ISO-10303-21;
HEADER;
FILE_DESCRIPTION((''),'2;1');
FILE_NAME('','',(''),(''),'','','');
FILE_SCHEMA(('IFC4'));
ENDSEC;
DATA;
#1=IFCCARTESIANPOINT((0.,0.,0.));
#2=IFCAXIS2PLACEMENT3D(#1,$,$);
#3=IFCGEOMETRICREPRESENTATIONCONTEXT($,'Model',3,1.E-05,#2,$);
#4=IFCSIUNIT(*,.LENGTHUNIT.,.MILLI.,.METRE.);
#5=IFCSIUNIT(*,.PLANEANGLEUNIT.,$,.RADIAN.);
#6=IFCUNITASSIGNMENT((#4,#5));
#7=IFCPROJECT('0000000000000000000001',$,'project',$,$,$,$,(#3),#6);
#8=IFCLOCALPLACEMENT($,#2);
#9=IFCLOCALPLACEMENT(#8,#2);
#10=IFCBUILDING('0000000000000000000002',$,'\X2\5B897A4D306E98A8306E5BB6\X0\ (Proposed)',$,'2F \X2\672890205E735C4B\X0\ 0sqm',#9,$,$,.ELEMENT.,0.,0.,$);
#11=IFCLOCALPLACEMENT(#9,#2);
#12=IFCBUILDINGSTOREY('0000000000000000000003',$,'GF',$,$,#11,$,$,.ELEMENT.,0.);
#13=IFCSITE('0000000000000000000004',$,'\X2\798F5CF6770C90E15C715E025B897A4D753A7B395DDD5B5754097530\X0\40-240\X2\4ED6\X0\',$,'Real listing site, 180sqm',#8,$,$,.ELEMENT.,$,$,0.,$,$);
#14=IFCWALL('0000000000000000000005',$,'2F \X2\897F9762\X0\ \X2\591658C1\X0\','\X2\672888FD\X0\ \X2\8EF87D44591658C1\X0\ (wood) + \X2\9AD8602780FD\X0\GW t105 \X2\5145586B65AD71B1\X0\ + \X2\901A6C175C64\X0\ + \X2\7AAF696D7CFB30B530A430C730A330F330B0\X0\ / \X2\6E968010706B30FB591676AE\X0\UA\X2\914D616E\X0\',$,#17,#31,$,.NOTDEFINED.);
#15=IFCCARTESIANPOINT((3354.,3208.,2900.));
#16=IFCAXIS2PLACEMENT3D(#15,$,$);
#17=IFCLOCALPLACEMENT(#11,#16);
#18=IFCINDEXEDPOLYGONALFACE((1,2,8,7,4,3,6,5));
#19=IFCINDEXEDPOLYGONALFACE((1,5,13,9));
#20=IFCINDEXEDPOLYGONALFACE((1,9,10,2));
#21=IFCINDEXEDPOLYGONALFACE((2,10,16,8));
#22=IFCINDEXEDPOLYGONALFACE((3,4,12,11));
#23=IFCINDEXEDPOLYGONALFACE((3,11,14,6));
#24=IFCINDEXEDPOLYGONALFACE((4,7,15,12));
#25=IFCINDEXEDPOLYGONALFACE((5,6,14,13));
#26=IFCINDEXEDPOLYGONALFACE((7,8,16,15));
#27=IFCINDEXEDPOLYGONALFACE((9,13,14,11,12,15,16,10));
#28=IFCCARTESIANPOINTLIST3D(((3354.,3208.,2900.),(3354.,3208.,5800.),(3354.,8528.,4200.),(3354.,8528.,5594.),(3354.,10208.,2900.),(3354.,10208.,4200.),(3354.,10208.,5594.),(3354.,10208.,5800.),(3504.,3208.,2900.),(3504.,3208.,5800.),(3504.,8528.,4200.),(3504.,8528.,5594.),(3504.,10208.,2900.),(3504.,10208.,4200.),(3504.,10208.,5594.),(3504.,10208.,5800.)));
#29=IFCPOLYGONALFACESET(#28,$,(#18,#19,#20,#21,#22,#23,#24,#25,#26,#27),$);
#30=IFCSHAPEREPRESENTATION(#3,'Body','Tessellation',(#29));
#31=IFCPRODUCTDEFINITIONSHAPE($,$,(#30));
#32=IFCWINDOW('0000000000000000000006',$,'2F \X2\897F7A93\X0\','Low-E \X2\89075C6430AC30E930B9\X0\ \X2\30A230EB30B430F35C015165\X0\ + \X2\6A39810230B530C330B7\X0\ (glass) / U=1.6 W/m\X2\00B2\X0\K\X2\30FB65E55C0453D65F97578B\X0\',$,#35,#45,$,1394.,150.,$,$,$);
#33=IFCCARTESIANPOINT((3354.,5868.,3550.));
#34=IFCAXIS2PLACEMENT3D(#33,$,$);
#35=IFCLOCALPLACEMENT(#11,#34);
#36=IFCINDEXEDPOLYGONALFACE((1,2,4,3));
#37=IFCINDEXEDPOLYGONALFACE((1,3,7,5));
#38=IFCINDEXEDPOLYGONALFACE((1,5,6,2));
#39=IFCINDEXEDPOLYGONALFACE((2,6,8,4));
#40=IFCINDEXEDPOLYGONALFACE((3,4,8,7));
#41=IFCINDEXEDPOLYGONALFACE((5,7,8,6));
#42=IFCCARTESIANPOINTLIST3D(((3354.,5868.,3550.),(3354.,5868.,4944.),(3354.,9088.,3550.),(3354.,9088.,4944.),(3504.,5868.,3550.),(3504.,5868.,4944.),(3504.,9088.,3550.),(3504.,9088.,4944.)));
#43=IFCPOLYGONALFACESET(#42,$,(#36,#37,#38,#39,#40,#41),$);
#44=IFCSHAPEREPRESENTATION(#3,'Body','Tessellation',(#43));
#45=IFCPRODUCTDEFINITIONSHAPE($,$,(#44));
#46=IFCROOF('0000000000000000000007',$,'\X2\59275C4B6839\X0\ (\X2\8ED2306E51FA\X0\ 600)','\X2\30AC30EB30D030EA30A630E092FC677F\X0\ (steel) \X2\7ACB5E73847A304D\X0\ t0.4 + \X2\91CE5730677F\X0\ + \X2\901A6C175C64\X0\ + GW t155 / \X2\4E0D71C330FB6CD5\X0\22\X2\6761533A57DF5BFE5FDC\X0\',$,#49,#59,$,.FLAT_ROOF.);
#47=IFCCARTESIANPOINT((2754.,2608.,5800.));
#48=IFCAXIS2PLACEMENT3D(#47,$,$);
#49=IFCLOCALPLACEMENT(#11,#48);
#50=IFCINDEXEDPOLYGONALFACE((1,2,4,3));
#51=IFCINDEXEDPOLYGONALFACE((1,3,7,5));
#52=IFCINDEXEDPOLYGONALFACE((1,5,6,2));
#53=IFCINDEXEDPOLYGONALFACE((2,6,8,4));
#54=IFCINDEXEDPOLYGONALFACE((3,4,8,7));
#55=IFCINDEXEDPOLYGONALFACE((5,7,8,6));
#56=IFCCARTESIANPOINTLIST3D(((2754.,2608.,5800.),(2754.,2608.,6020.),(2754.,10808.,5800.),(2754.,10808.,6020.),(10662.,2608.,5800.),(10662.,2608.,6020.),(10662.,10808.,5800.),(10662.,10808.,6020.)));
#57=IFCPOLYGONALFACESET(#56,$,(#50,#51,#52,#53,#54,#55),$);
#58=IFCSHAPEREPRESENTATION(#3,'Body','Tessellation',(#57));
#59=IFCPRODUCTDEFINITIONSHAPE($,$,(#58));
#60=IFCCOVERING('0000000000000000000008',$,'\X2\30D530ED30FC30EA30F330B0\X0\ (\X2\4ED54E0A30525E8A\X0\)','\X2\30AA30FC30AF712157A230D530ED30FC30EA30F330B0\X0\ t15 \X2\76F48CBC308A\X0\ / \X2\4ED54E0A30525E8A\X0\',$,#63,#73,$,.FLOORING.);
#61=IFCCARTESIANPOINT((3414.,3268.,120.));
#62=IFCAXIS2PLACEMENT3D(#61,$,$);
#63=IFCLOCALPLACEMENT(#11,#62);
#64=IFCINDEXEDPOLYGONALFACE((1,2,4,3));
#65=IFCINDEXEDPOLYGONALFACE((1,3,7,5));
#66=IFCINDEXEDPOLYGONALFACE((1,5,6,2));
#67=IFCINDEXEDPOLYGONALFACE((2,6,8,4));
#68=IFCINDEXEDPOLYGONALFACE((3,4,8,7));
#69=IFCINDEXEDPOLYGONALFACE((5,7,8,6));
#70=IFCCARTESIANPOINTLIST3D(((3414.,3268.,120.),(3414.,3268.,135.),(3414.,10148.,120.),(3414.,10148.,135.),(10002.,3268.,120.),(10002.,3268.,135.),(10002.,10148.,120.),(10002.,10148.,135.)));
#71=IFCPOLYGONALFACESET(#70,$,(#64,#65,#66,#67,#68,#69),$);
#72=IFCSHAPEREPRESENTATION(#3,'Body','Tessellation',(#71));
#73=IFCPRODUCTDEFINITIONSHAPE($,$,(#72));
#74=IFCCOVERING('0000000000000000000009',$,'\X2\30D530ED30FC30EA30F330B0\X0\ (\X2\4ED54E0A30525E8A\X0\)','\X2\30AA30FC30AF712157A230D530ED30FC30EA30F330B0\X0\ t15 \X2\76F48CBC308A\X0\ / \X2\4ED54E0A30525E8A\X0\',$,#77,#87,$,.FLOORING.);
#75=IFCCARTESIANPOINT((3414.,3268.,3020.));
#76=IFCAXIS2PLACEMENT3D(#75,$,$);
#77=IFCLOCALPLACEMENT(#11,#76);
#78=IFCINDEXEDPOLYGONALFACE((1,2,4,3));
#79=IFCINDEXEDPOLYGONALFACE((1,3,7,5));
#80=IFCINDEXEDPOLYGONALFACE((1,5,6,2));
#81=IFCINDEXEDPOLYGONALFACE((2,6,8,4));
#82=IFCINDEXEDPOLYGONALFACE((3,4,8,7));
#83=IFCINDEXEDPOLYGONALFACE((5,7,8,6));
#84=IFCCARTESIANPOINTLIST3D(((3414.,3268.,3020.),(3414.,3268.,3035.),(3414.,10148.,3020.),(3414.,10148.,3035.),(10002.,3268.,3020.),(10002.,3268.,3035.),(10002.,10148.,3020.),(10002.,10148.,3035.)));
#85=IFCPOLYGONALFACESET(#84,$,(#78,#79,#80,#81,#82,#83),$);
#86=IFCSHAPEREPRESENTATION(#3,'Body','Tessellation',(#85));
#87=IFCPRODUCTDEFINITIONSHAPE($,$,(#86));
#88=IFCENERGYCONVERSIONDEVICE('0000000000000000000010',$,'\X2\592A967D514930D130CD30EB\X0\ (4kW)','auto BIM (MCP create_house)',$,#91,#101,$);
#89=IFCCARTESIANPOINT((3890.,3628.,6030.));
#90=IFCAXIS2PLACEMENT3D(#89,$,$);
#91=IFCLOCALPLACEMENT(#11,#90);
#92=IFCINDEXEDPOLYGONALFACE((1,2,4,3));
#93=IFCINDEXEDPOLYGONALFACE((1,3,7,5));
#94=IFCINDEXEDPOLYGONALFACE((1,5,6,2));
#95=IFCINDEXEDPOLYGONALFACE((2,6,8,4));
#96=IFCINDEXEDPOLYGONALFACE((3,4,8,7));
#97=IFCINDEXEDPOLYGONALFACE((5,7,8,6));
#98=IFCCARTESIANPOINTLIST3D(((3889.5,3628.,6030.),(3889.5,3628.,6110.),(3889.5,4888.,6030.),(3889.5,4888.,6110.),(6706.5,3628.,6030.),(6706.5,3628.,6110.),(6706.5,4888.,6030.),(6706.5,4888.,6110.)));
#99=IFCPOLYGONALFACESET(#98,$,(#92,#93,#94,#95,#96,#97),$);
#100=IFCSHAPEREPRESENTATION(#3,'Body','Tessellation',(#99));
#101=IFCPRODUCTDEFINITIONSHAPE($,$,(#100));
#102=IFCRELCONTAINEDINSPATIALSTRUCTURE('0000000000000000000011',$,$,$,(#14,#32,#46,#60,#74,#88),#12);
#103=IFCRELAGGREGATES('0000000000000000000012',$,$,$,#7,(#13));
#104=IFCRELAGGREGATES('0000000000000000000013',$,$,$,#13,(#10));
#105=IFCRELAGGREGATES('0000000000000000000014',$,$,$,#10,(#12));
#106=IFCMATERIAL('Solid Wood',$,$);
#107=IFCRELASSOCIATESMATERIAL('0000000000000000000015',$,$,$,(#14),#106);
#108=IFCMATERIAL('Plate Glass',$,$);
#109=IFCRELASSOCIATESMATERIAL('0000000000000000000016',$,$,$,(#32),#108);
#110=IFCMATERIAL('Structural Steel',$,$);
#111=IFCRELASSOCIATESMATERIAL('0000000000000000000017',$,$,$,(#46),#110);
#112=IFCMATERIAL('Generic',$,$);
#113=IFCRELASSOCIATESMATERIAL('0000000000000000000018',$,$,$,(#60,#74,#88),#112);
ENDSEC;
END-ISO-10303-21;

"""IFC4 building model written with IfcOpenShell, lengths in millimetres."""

from ifc_helpers import new_model, si_unit, frame, frame_2d, origin, place, context, project, spatial, rectangle, extrude, material, element, fill, save


model = new_model("IFC4")

# Units and contexts
model_context = context("Model", 3, precision=1e-05, world=origin())
ifc_project = project(units=[si_unit("LENGTHUNIT", "METRE", prefix="MILLI"), si_unit("PLANEANGLEUNIT", "RADIAN")], contexts=[model_context])

# Site, building, storey
site_placement = place(None, origin())
site = spatial("IfcSite", under=ifc_project, at=site_placement, Name="福島県郡山市安積町笹川字吉田40-240他", ObjectType="Real listing site, 180sqm", CompositionType="ELEMENT", RefElevation=0.0)
building_placement = place(site_placement, origin())
building = spatial("IfcBuilding", under=site, at=building_placement, Name="安積の風の家 (Proposed)", ObjectType="2F 木造平屋 0sqm", CompositionType="ELEMENT", ElevationOfRefHeight=0.0, ElevationOfTerrain=0.0)
storey_placement = place(building_placement, origin())
storey = spatial("IfcBuildingStorey", under=building, at=storey_placement, Name="GF", CompositionType="ELEMENT", Elevation=0.0)

# Shared definitions
ifc_material_1 = material(Name="Solid Wood")

# Shared definitions
ifc_material_2 = material(Name="Plate Glass")

# Wall, opening, window
wall_1_placement = place(storey_placement, frame((3354.0, 3208.0, 2900.0)))
wall_1 = element("IfcWall", 1, at=wall_1_placement, inside=storey, material=ifc_material_1, Name="2F 西面 外壁", Description="木製 軸組外壁 (wood) + 高性能GW t105 充填断熱 + 通気層 + 窯業系サイディング / 準耐火・外皮UA配慮", PredefinedType="NOTDEFINED", context=model_context, shape_type="SweptSolid", body=[
    extrude(rectangle(XDim=150.0, YDim=7000.0, at=frame_2d((75.0, 3500.0))), frame((3354.0, 3208.0, 2900.0)), (0.0, 0.0, 1.0), 2900.0),
])
opening_1_placement = place(storey_placement, frame((3354.0, 5868.0, 3550.0)))
opening_1 = element("IfcOpeningElement", 2, at=opening_1_placement, cuts=wall_1, PredefinedType="NOTDEFINED", context=model_context, shape_type="SweptSolid", body=[
    extrude(rectangle(XDim=150.0, YDim=3220.0, at=frame_2d((75.0, 1610.0))), frame((3354.0, 5868.0, 3550.0)), (0.0, 0.0, 1.0), 1394.0),
])
window_1_placement = place(storey_placement, frame((3354.0, 5868.0, 3550.0)))
window_1 = element("IfcWindow", 3, at=window_1_placement, inside=storey, material=ifc_material_2, Name="2F 西窓", Description="Low-E 複層ガラス アルゴン封入 + 樹脂サッシ (glass) / U=1.6 W/m²K・日射取得型", OverallHeight=1394.0, OverallWidth=150.0, context=model_context, shape_type="SweptSolid", body=[
    extrude(rectangle(XDim=150.0, YDim=3220.0, at=frame_2d((75.0, 1610.0))), frame((3354.0, 5868.0, 3550.0)), (0.0, 0.0, 1.0), 1394.0),
])
fill(opening_1, window_1)

# Roof
ifc_material_3 = material(Name="Structural Steel")
roof_placement = place(storey_placement, frame((2754.0, 2608.0, 5800.0)))
element("IfcRoof", 4, at=roof_placement, inside=storey, material=ifc_material_3, Name="大屋根 (軒の出 600)", Description="ガルバリウム鋼板 (steel) 立平葺き t0.4 + 野地板 + 通気層 + GW t155 / 不燃・法22条区域対応", PredefinedType="FLAT_ROOF", context=model_context, shape_type="SweptSolid", body=[
    extrude(rectangle(XDim=7908.0, YDim=8200.0, at=frame_2d((3954.0, 4100.0))), frame((2754.0, 2608.0, 5800.0)), (0.0, 0.0, 1.0), 220.0),
])

# Coverings
ifc_material_4 = material(Name="Generic")
covering_1_placement = place(storey_placement, frame((3414.0, 3268.0, 120.0)))
element("IfcCovering", 5, at=covering_1_placement, inside=storey, material=ifc_material_4, Name="フローリング (仕上げ床)", Description="オーク無垢フローリング t15 直貼り / 仕上げ床", PredefinedType="FLOORING", context=model_context, shape_type="SweptSolid", body=[
    extrude(rectangle(XDim=6588.0, YDim=6880.0, at=frame_2d((3294.0, 3440.0))), frame((3414.0, 3268.0, 120.0)), (0.0, 0.0, 1.0), 15.0),
])
covering_2_placement = place(storey_placement, frame((3414.0, 3268.0, 3020.0)))
element("IfcCovering", 6, at=covering_2_placement, inside=storey, material=ifc_material_4, Name="フローリング (仕上げ床)", Description="オーク無垢フローリング t15 直貼り / 仕上げ床", PredefinedType="FLOORING", context=model_context, shape_type="SweptSolid", body=[
    extrude(rectangle(XDim=6588.0, YDim=6880.0, at=frame_2d((3294.0, 3440.0))), frame((3414.0, 3268.0, 3020.0)), (0.0, 0.0, 1.0), 15.0),
])

# Energy conversion device
energy_conversion_device_placement = place(storey_placement, frame((3890.0, 3628.0, 6030.0)))
element("IfcEnergyConversionDevice", 7, at=energy_conversion_device_placement, inside=storey, material=ifc_material_4, Name="太陽光パネル (4kW)", Description="auto BIM (MCP create_house)", context=model_context, shape_type="SweptSolid", body=[
    extrude(rectangle(XDim=2817.0, YDim=1260.0, at=frame_2d((1408.0, 630.0))), frame((3890.0, 3628.0, 6030.0)), (0.0, 0.0, 1.0), 80.0),
])

save(model, "model.ifc")
